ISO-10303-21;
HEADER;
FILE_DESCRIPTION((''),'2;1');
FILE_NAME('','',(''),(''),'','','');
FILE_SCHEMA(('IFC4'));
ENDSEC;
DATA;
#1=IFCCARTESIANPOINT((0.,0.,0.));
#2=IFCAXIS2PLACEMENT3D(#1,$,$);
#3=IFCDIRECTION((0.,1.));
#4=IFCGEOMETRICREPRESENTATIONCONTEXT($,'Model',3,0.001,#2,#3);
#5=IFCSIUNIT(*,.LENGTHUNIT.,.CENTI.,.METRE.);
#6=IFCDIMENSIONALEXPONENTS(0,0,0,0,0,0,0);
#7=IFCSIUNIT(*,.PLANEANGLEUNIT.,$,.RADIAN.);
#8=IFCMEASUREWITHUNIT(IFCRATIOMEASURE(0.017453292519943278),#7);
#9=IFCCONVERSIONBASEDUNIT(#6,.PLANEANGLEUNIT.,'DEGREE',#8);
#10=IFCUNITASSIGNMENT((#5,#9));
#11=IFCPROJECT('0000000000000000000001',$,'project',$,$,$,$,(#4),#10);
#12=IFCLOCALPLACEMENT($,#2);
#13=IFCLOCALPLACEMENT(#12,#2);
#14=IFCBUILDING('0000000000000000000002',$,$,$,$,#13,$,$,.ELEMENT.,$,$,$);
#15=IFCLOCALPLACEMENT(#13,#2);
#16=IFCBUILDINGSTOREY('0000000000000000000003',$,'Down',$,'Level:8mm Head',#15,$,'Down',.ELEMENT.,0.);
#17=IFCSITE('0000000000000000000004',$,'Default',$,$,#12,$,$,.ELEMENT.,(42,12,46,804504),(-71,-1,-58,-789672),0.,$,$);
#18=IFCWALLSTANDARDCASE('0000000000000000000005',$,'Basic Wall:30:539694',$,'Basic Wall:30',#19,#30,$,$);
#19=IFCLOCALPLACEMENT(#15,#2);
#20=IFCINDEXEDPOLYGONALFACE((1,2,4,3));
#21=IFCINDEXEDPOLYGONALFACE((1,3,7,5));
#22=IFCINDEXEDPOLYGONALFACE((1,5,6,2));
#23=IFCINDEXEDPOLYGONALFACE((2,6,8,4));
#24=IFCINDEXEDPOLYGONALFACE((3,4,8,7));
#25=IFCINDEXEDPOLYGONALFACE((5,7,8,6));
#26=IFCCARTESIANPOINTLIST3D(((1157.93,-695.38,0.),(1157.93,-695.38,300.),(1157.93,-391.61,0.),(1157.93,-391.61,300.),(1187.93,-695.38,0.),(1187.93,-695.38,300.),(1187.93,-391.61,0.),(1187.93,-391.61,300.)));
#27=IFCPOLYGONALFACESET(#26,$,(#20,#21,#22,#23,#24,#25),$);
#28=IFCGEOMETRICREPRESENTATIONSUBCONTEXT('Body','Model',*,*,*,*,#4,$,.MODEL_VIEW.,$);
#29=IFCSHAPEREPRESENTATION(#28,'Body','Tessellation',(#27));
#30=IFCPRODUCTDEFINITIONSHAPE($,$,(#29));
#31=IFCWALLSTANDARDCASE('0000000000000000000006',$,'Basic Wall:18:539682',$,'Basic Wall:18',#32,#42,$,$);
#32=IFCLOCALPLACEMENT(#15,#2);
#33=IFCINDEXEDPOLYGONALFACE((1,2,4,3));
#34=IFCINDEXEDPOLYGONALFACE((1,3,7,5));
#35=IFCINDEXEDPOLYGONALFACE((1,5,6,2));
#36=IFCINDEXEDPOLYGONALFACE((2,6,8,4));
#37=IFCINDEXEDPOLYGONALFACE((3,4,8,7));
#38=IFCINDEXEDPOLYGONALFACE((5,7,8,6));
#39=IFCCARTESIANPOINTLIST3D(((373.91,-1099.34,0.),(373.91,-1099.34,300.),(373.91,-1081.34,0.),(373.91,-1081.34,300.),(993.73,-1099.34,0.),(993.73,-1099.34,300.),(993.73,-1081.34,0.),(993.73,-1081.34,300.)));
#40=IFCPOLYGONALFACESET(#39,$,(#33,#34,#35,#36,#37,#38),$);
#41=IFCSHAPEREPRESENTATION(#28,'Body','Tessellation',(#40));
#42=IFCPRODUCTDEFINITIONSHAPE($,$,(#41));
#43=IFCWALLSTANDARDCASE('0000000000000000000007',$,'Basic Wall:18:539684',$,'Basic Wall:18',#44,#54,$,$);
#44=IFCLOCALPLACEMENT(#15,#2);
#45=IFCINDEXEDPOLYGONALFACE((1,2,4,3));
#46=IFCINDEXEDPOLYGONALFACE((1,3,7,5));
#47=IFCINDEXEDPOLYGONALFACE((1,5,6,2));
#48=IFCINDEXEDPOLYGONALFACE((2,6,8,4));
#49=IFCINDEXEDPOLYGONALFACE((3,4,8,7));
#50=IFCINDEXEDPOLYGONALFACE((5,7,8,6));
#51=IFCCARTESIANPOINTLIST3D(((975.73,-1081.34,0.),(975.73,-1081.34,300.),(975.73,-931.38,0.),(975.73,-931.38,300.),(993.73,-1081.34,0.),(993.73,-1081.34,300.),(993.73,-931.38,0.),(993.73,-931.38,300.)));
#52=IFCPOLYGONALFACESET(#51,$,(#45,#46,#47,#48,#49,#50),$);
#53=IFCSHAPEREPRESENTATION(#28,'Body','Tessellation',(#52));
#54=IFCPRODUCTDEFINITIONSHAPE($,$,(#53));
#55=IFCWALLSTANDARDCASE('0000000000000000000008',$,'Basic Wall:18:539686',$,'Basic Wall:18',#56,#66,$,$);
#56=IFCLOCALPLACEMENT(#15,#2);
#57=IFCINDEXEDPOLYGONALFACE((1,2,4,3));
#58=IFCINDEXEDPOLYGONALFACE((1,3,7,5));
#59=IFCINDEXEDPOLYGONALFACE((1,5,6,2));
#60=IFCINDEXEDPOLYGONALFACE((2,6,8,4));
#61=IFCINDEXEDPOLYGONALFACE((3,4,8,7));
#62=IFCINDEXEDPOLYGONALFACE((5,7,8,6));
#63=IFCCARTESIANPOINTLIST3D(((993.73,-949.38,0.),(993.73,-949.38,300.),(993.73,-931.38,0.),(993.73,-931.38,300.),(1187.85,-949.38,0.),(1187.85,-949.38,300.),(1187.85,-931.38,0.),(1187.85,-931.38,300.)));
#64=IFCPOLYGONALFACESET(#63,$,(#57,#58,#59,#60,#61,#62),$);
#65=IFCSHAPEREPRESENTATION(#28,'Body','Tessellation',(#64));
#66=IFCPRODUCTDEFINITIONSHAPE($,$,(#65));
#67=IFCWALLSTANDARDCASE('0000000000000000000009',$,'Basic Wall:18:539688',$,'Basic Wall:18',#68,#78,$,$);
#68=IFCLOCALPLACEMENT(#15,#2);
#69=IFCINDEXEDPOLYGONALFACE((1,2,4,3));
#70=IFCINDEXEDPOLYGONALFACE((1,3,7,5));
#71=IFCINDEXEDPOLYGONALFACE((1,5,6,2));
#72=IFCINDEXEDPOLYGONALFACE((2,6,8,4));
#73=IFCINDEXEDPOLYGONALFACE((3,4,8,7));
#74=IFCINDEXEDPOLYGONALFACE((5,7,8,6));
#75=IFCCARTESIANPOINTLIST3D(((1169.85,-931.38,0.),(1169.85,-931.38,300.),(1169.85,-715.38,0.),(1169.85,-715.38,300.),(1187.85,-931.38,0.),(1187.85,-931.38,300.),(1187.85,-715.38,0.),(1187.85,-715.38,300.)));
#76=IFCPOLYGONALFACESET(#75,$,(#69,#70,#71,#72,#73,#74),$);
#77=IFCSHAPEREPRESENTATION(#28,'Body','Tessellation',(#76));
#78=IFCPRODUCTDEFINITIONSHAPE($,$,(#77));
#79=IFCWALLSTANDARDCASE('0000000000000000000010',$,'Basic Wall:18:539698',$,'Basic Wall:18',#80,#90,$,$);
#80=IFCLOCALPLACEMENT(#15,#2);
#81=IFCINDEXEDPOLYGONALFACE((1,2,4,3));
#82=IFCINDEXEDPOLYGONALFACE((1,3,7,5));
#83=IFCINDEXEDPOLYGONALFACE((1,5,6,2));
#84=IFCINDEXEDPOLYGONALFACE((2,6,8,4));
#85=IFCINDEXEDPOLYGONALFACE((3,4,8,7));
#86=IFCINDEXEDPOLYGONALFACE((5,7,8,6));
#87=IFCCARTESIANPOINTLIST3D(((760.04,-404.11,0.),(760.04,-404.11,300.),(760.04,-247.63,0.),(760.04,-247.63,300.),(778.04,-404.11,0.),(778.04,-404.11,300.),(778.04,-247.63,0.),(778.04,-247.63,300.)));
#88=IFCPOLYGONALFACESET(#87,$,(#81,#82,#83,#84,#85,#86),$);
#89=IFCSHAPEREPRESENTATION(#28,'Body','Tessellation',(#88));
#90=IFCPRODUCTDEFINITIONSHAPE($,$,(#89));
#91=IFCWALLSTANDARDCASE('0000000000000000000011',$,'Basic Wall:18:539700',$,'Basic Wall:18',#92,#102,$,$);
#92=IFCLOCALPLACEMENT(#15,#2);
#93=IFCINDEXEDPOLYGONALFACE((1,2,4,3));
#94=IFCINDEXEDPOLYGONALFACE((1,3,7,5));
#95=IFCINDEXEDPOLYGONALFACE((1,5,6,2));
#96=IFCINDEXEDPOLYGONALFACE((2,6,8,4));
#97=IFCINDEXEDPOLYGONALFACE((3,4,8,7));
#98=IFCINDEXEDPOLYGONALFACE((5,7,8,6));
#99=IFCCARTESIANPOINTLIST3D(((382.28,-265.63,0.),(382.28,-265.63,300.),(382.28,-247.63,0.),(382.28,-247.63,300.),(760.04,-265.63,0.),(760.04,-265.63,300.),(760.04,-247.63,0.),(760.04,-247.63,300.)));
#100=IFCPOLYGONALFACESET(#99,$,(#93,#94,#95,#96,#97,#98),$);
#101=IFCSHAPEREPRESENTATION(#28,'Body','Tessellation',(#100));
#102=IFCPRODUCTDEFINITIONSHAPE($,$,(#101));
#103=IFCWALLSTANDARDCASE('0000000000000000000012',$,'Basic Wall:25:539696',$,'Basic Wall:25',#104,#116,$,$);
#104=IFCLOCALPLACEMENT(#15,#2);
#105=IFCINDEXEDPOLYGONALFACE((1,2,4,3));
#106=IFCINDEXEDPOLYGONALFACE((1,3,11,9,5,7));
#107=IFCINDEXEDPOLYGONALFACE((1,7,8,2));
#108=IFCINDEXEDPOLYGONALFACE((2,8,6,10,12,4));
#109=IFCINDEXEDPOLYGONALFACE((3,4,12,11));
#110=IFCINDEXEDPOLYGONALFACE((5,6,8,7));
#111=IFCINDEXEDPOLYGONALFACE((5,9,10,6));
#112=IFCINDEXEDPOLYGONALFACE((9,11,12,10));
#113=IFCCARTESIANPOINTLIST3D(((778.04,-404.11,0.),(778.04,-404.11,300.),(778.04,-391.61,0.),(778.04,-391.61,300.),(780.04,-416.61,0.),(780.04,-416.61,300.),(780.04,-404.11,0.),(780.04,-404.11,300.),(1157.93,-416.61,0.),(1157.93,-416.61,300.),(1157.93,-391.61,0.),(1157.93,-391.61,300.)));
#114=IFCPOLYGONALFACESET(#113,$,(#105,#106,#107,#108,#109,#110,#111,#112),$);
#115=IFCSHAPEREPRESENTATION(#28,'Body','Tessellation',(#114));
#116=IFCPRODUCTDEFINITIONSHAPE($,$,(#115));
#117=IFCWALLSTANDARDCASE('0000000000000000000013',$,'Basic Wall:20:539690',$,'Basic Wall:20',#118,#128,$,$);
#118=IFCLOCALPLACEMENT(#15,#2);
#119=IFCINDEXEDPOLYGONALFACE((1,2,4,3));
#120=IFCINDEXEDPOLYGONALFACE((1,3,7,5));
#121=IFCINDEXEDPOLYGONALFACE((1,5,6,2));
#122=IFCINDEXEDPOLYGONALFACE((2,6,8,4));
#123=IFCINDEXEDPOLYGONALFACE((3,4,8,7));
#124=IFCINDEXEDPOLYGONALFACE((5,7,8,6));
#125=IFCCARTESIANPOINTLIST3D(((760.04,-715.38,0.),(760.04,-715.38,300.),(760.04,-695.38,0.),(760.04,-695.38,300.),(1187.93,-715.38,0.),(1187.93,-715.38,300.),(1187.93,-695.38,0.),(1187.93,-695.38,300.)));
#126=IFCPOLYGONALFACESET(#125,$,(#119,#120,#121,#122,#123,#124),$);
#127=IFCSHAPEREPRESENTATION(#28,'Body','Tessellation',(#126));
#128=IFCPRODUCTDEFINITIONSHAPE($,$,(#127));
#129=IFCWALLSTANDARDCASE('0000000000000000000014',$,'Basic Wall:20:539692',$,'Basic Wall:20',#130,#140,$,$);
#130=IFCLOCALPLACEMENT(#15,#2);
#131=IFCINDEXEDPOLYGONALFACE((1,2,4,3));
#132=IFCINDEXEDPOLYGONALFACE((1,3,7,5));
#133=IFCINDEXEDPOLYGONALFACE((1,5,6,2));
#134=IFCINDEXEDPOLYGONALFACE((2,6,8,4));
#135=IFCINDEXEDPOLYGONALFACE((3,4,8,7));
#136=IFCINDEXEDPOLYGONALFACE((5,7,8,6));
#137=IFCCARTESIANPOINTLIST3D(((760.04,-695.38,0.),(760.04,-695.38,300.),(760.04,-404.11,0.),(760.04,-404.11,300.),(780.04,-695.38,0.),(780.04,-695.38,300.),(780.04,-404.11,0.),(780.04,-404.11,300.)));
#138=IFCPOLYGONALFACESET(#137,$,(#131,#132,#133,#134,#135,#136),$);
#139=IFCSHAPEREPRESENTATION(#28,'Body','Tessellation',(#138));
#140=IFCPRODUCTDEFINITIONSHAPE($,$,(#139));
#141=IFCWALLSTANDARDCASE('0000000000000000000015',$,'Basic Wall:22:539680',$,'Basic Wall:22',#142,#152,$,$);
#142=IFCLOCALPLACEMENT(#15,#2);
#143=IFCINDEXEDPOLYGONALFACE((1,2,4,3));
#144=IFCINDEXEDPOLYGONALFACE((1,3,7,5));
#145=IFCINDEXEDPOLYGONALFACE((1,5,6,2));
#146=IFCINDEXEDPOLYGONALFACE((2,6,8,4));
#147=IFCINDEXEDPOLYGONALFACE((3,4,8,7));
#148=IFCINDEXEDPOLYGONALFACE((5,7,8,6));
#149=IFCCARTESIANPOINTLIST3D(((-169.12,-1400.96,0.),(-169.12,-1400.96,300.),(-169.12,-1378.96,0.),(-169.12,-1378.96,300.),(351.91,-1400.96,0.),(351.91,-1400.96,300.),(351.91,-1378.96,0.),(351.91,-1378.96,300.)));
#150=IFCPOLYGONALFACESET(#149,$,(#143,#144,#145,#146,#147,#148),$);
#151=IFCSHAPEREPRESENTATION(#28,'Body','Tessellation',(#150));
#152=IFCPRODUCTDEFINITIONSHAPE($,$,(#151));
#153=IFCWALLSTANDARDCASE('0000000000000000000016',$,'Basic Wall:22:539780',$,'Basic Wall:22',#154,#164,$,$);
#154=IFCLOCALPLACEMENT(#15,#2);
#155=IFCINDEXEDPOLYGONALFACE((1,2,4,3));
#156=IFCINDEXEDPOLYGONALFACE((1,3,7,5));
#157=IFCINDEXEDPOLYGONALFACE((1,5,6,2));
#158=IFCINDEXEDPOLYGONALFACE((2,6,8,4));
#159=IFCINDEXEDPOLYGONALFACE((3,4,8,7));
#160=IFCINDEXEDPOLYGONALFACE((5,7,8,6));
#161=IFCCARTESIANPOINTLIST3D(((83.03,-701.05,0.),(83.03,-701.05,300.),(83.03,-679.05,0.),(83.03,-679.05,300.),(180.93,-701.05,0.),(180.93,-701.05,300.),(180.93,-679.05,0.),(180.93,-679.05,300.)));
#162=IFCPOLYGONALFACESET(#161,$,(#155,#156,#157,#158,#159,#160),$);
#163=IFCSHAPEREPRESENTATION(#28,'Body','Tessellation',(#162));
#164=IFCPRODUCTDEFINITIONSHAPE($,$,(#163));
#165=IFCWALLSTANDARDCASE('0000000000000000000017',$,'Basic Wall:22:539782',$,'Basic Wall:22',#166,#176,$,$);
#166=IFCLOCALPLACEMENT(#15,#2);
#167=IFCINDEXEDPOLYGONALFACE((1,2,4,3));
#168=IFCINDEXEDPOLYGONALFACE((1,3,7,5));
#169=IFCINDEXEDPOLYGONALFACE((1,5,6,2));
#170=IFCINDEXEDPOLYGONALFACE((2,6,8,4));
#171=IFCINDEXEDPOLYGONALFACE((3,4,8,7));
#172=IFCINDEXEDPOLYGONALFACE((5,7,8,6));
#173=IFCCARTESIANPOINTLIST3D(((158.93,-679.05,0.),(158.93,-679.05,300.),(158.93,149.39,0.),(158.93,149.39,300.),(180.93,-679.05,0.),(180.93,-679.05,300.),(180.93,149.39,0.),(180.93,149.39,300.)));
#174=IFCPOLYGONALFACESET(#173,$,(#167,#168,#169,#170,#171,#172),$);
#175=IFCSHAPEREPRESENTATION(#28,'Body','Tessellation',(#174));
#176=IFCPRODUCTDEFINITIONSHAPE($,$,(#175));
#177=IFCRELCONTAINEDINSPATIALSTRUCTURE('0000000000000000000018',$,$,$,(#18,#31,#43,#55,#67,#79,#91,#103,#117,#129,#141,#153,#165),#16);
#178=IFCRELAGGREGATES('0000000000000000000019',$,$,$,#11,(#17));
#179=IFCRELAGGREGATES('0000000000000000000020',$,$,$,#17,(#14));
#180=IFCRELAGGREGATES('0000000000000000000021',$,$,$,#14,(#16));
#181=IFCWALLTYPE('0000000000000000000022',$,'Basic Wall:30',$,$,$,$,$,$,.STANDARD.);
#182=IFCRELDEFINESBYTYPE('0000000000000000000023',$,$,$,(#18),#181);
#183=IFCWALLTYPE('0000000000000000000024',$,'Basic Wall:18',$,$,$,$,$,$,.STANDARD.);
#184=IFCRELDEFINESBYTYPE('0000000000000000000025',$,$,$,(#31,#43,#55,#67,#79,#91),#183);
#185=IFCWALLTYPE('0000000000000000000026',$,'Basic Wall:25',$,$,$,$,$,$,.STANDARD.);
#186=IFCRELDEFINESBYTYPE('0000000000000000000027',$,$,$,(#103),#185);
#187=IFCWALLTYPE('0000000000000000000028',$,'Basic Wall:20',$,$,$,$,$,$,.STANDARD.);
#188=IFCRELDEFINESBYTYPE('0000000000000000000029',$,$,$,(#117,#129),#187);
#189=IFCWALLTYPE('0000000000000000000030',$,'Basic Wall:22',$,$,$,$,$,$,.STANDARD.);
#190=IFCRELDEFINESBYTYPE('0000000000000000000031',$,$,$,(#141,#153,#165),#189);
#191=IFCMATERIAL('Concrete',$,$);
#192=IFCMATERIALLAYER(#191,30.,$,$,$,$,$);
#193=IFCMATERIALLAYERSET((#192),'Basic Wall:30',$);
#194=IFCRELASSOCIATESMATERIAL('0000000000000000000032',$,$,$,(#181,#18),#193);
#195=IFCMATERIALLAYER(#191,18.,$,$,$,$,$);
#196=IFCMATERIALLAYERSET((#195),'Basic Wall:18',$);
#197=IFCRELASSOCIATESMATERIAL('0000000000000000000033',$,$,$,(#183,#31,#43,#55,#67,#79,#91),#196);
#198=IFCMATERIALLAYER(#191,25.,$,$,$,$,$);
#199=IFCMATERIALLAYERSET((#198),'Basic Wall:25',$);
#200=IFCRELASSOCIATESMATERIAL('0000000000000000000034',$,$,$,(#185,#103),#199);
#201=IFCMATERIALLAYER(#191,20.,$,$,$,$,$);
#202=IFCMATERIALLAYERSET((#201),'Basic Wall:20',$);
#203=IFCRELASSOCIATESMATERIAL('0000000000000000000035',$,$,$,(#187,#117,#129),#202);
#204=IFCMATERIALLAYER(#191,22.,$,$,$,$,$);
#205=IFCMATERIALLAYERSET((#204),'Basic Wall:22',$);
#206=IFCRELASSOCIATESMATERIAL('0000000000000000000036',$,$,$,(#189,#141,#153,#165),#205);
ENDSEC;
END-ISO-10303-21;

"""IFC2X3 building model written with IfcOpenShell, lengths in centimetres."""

from ifc_helpers import new_model, entity, si_unit, converted_unit, direction, frame, frame_2d, origin, place, context, subcontext, project, spatial, polyline, rectangle, outline, extrude, material, layer, layer_set, layer_usage, type_object, element, save


model = new_model("IFC2X3")

# Units and contexts
model_context = context("Model", 3, precision=0.001, world=origin(), true_north=direction((0.0, 1.0)))
body_context = subcontext(model_context, "Body", "Model", "MODEL_VIEW")
ifc_project = project(units=[si_unit("LENGTHUNIT", "METRE", prefix="CENTI"), converted_unit("PLANEANGLEUNIT", "DEGREE", entity("IfcRatioMeasure", 0.017453292519943278), si_unit("PLANEANGLEUNIT", "RADIAN"), dimensions=[0, 0, 0, 0, 0, 0, 0])], contexts=[model_context])

# Site, building, storey
site_placement = place(None, origin())
site = spatial("IfcSite", under=ifc_project, at=site_placement, Name="Default", CompositionType="ELEMENT", RefLatitude=(42, 12, 46, 804504), RefLongitude=(-71, -1, -58, -789672), RefElevation=0.0)
building_placement = place(site_placement, origin())
building = spatial("IfcBuilding", under=site, at=building_placement, CompositionType="ELEMENT")
storey_placement = place(building_placement, origin())
storey = spatial("IfcBuildingStorey", under=building, at=storey_placement, Name="Down", ObjectType="Level:8mm Head", LongName="Down", CompositionType="ELEMENT", Elevation=0.0)

# Walls
ifc_material = material(Name="Concrete")
ifc_layer_1 = layer(ifc_material, 30.0)
ifc_layer_set_1 = layer_set([ifc_layer_1], Name="Basic Wall:30")
ifc_layer_usage_1 = layer_usage(ifc_layer_set_1, "AXIS2", "POSITIVE", -15.0)
wall_type_1 = type_object("IfcWallType", Name="Basic Wall:30", PredefinedType="STANDARD", material=ifc_layer_set_1)
wall_1_placement = place(storey_placement, frame((1172.93, -695.38, 0.0), z_axis=(0.0, 0.0, 1.0), x_axis=(0.0, 1.0, 0.0)))
element("IfcWallStandardCase", 1, at=wall_1_placement, inside=storey, type_object=wall_type_1, material=ifc_layer_usage_1, Name="Basic Wall:30:539694", ObjectType="Basic Wall:30", context=body_context, shape_type="SweptSolid", body=[
    extrude(rectangle(XDim=303.76, YDim=30.0, at=frame_2d((151.88, 0.0), x_axis=(-1.0, 0.0))), origin(), (0.0, 0.0, 1.0), 300.0),
])
ifc_layer_2 = layer(ifc_material, 18.0)
ifc_layer_set_2 = layer_set([ifc_layer_2], Name="Basic Wall:18")
ifc_layer_usage_2 = layer_usage(ifc_layer_set_2, "AXIS2", "POSITIVE", -9.0)
wall_type_2 = type_object("IfcWallType", Name="Basic Wall:18", PredefinedType="STANDARD", material=ifc_layer_set_2)
wall_2_placement = place(storey_placement, frame((993.73, -1090.34, 0.0), z_axis=(0.0, 0.0, 1.0), x_axis=(-1.0, 0.0, 0.0)))
element("IfcWallStandardCase", 2, at=wall_2_placement, inside=storey, type_object=wall_type_2, material=ifc_layer_usage_2, Name="Basic Wall:18:539682", ObjectType="Basic Wall:18", context=body_context, shape_type="SweptSolid", body=[
    extrude(rectangle(XDim=619.82, YDim=18.0, at=frame_2d((309.91, 0.0), x_axis=(-1.0, 0.0))), origin(), (0.0, 0.0, 1.0), 300.0),
])
ifc_layer_usage_3 = layer_usage(ifc_layer_set_2, "AXIS2", "NEGATIVE", 9.0)
wall_3_placement = place(storey_placement, frame((984.73, -931.38, 0.0), z_axis=(0.0, 0.0, 1.0), x_axis=(0.0, -1.0, 0.0)))
element("IfcWallStandardCase", 3, at=wall_3_placement, inside=storey, type_object=wall_type_2, material=ifc_layer_usage_3, Name="Basic Wall:18:539684", ObjectType="Basic Wall:18", context=body_context, shape_type="SweptSolid", body=[
    extrude(rectangle(XDim=149.97, YDim=18.0, at=frame_2d((74.98, 0.0), x_axis=(-1.0, 0.0))), origin(), (0.0, 0.0, 1.0), 300.0),
])
ifc_layer_usage_4 = layer_usage(ifc_layer_set_2, "AXIS2", "NEGATIVE", 9.0)
wall_4_placement = place(storey_placement, frame((993.73, -940.38, 0.0)))
element("IfcWallStandardCase", 4, at=wall_4_placement, inside=storey, type_object=wall_type_2, material=ifc_layer_usage_4, Name="Basic Wall:18:539686", ObjectType="Basic Wall:18", context=body_context, shape_type="SweptSolid", body=[
    extrude(rectangle(XDim=194.12, YDim=18.0, at=frame_2d((97.06, 0.0), x_axis=(-1.0, 0.0))), origin(), (0.0, 0.0, 1.0), 300.0),
])
ifc_layer_usage_5 = layer_usage(ifc_layer_set_2, "AXIS2", "NEGATIVE", 9.0)
wall_5_placement = place(storey_placement, frame((1178.85, -931.38, 0.0), z_axis=(0.0, 0.0, 1.0), x_axis=(0.0, 1.0, 0.0)))
element("IfcWallStandardCase", 5, at=wall_5_placement, inside=storey, type_object=wall_type_2, material=ifc_layer_usage_5, Name="Basic Wall:18:539688", ObjectType="Basic Wall:18", context=body_context, shape_type="SweptSolid", body=[
    extrude(rectangle(XDim=216.0, YDim=18.0, at=frame_2d((108.0, 0.0), x_axis=(-1.0, 0.0))), origin(), (0.0, 0.0, 1.0), 300.0),
])
ifc_layer_usage_6 = layer_usage(ifc_layer_set_2, "AXIS2", "POSITIVE", -9.0)
wall_6_placement = place(storey_placement, frame((769.04, -404.11, 0.0), z_axis=(0.0, 0.0, 1.0), x_axis=(0.0, 1.0, 0.0)))
element("IfcWallStandardCase", 6, at=wall_6_placement, inside=storey, type_object=wall_type_2, material=ifc_layer_usage_6, Name="Basic Wall:18:539698", ObjectType="Basic Wall:18", context=body_context, shape_type="SweptSolid", body=[
    extrude(rectangle(XDim=156.48, YDim=18.0, at=frame_2d((78.24, 0.0), x_axis=(-1.0, 0.0))), origin(), (0.0, 0.0, 1.0), 300.0),
])
ifc_layer_usage_7 = layer_usage(ifc_layer_set_2, "AXIS2", "NEGATIVE", 9.0)
wall_7_placement = place(storey_placement, frame((760.04, -256.63, 0.0), z_axis=(0.0, 0.0, 1.0), x_axis=(-1.0, 0.0, 0.0)))
element("IfcWallStandardCase", 7, at=wall_7_placement, inside=storey, type_object=wall_type_2, material=ifc_layer_usage_7, Name="Basic Wall:18:539700", ObjectType="Basic Wall:18", context=body_context, shape_type="SweptSolid", body=[
    extrude(rectangle(XDim=377.76, YDim=18.0, at=frame_2d((188.88, 0.0), x_axis=(-1.0, 0.0))), origin(), (0.0, 0.0, 1.0), 300.0),
])
ifc_layer_3 = layer(ifc_material, 25.0)
ifc_layer_set_3 = layer_set([ifc_layer_3], Name="Basic Wall:25")
ifc_layer_usage_8 = layer_usage(ifc_layer_set_3, "AXIS2", "NEGATIVE", 12.5)
wall_type_3 = type_object("IfcWallType", Name="Basic Wall:25", PredefinedType="STANDARD", material=ifc_layer_set_3)
wall_8_placement = place(storey_placement, frame((1157.93, -404.11, 0.0), z_axis=(0.0, 0.0, 1.0), x_axis=(-1.0, 0.0, 0.0)))
element("IfcWallStandardCase", 8, at=wall_8_placement, inside=storey, type_object=wall_type_3, material=ifc_layer_usage_8, Name="Basic Wall:25:539696", ObjectType="Basic Wall:25", context=body_context, shape_type="SweptSolid", body=[
    extrude(outline(polyline([(379.89, -12.5), (379.89, 0.0), (377.89, 0.0), (377.89, 12.5), (0.0, 12.5), (0.0, -12.5), (379.89, -12.5)])), origin(), (0.0, 0.0, 1.0), 300.0),
])
ifc_layer_4 = layer(ifc_material, 20.0)
ifc_layer_set_4 = layer_set([ifc_layer_4], Name="Basic Wall:20")
ifc_layer_usage_9 = layer_usage(ifc_layer_set_4, "AXIS2", "POSITIVE", -10.0)
wall_type_4 = type_object("IfcWallType", Name="Basic Wall:20", PredefinedType="STANDARD", material=ifc_layer_set_4)
wall_9_placement = place(storey_placement, frame((1187.93, -705.38, 0.0), z_axis=(0.0, 0.0, 1.0), x_axis=(-1.0, 0.0, 0.0)))
element("IfcWallStandardCase", 9, at=wall_9_placement, inside=storey, type_object=wall_type_4, material=ifc_layer_usage_9, Name="Basic Wall:20:539690", ObjectType="Basic Wall:20", context=body_context, shape_type="SweptSolid", body=[
    extrude(rectangle(XDim=427.89, YDim=20.0, at=frame_2d((213.94, 0.0), x_axis=(-1.0, 0.0))), origin(), (0.0, 0.0, 1.0), 300.0),
])
ifc_layer_usage_10 = layer_usage(ifc_layer_set_4, "AXIS2", "POSITIVE", -10.0)
wall_10_placement = place(storey_placement, frame((770.04, -695.38, 0.0), z_axis=(0.0, 0.0, 1.0), x_axis=(0.0, 1.0, 0.0)))
element("IfcWallStandardCase", 10, at=wall_10_placement, inside=storey, type_object=wall_type_4, material=ifc_layer_usage_10, Name="Basic Wall:20:539692", ObjectType="Basic Wall:20", context=body_context, shape_type="SweptSolid", body=[
    extrude(rectangle(XDim=291.26, YDim=20.0, at=frame_2d((145.63, 0.0), x_axis=(-1.0, 0.0))), origin(), (0.0, 0.0, 1.0), 300.0),
])
ifc_layer_5 = layer(ifc_material, 22.0)
ifc_layer_set_5 = layer_set([ifc_layer_5], Name="Basic Wall:22")
ifc_layer_usage_11 = layer_usage(ifc_layer_set_5, "AXIS2", "POSITIVE", -11.0)
wall_type_5 = type_object("IfcWallType", Name="Basic Wall:22", PredefinedType="STANDARD", material=ifc_layer_set_5)
wall_11_placement = place(storey_placement, frame((351.91, -1389.96, 0.0), z_axis=(0.0, 0.0, 1.0), x_axis=(-1.0, 0.0, 0.0)))
element("IfcWallStandardCase", 11, at=wall_11_placement, inside=storey, type_object=wall_type_5, material=ifc_layer_usage_11, Name="Basic Wall:22:539680", ObjectType="Basic Wall:22", context=body_context, shape_type="SweptSolid", body=[
    extrude(rectangle(XDim=521.03, YDim=22.0, at=frame_2d((260.51, 0.0), x_axis=(-1.0, 0.0))), origin(), (0.0, 0.0, 1.0), 300.0),
])
ifc_layer_usage_12 = layer_usage(ifc_layer_set_5, "AXIS2", "POSITIVE", -11.0)
wall_12_placement = place(storey_placement, frame((180.93, -690.05, 0.0), z_axis=(0.0, 0.0, 1.0), x_axis=(-1.0, 0.0, 0.0)))
element("IfcWallStandardCase", 12, at=wall_12_placement, inside=storey, type_object=wall_type_5, material=ifc_layer_usage_12, Name="Basic Wall:22:539780", ObjectType="Basic Wall:22", context=body_context, shape_type="SweptSolid", body=[
    extrude(rectangle(XDim=97.9, YDim=22.0, at=frame_2d((48.95, 0.0), x_axis=(-1.0, 0.0))), origin(), (0.0, 0.0, 1.0), 300.0),
])
ifc_layer_usage_13 = layer_usage(ifc_layer_set_5, "AXIS2", "POSITIVE", -11.0)
wall_13_placement = place(storey_placement, frame((169.93, -679.05, 0.0), z_axis=(0.0, 0.0, 1.0), x_axis=(0.0, 1.0, 0.0)))
element("IfcWallStandardCase", 13, at=wall_13_placement, inside=storey, type_object=wall_type_5, material=ifc_layer_usage_13, Name="Basic Wall:22:539782", ObjectType="Basic Wall:22", context=body_context, shape_type="SweptSolid", body=[
    extrude(rectangle(XDim=828.44, YDim=22.0, at=frame_2d((414.22, 0.0), x_axis=(-1.0, 0.0))), origin(), (0.0, 0.0, 1.0), 300.0),
])

save(model, "model.ifc")
